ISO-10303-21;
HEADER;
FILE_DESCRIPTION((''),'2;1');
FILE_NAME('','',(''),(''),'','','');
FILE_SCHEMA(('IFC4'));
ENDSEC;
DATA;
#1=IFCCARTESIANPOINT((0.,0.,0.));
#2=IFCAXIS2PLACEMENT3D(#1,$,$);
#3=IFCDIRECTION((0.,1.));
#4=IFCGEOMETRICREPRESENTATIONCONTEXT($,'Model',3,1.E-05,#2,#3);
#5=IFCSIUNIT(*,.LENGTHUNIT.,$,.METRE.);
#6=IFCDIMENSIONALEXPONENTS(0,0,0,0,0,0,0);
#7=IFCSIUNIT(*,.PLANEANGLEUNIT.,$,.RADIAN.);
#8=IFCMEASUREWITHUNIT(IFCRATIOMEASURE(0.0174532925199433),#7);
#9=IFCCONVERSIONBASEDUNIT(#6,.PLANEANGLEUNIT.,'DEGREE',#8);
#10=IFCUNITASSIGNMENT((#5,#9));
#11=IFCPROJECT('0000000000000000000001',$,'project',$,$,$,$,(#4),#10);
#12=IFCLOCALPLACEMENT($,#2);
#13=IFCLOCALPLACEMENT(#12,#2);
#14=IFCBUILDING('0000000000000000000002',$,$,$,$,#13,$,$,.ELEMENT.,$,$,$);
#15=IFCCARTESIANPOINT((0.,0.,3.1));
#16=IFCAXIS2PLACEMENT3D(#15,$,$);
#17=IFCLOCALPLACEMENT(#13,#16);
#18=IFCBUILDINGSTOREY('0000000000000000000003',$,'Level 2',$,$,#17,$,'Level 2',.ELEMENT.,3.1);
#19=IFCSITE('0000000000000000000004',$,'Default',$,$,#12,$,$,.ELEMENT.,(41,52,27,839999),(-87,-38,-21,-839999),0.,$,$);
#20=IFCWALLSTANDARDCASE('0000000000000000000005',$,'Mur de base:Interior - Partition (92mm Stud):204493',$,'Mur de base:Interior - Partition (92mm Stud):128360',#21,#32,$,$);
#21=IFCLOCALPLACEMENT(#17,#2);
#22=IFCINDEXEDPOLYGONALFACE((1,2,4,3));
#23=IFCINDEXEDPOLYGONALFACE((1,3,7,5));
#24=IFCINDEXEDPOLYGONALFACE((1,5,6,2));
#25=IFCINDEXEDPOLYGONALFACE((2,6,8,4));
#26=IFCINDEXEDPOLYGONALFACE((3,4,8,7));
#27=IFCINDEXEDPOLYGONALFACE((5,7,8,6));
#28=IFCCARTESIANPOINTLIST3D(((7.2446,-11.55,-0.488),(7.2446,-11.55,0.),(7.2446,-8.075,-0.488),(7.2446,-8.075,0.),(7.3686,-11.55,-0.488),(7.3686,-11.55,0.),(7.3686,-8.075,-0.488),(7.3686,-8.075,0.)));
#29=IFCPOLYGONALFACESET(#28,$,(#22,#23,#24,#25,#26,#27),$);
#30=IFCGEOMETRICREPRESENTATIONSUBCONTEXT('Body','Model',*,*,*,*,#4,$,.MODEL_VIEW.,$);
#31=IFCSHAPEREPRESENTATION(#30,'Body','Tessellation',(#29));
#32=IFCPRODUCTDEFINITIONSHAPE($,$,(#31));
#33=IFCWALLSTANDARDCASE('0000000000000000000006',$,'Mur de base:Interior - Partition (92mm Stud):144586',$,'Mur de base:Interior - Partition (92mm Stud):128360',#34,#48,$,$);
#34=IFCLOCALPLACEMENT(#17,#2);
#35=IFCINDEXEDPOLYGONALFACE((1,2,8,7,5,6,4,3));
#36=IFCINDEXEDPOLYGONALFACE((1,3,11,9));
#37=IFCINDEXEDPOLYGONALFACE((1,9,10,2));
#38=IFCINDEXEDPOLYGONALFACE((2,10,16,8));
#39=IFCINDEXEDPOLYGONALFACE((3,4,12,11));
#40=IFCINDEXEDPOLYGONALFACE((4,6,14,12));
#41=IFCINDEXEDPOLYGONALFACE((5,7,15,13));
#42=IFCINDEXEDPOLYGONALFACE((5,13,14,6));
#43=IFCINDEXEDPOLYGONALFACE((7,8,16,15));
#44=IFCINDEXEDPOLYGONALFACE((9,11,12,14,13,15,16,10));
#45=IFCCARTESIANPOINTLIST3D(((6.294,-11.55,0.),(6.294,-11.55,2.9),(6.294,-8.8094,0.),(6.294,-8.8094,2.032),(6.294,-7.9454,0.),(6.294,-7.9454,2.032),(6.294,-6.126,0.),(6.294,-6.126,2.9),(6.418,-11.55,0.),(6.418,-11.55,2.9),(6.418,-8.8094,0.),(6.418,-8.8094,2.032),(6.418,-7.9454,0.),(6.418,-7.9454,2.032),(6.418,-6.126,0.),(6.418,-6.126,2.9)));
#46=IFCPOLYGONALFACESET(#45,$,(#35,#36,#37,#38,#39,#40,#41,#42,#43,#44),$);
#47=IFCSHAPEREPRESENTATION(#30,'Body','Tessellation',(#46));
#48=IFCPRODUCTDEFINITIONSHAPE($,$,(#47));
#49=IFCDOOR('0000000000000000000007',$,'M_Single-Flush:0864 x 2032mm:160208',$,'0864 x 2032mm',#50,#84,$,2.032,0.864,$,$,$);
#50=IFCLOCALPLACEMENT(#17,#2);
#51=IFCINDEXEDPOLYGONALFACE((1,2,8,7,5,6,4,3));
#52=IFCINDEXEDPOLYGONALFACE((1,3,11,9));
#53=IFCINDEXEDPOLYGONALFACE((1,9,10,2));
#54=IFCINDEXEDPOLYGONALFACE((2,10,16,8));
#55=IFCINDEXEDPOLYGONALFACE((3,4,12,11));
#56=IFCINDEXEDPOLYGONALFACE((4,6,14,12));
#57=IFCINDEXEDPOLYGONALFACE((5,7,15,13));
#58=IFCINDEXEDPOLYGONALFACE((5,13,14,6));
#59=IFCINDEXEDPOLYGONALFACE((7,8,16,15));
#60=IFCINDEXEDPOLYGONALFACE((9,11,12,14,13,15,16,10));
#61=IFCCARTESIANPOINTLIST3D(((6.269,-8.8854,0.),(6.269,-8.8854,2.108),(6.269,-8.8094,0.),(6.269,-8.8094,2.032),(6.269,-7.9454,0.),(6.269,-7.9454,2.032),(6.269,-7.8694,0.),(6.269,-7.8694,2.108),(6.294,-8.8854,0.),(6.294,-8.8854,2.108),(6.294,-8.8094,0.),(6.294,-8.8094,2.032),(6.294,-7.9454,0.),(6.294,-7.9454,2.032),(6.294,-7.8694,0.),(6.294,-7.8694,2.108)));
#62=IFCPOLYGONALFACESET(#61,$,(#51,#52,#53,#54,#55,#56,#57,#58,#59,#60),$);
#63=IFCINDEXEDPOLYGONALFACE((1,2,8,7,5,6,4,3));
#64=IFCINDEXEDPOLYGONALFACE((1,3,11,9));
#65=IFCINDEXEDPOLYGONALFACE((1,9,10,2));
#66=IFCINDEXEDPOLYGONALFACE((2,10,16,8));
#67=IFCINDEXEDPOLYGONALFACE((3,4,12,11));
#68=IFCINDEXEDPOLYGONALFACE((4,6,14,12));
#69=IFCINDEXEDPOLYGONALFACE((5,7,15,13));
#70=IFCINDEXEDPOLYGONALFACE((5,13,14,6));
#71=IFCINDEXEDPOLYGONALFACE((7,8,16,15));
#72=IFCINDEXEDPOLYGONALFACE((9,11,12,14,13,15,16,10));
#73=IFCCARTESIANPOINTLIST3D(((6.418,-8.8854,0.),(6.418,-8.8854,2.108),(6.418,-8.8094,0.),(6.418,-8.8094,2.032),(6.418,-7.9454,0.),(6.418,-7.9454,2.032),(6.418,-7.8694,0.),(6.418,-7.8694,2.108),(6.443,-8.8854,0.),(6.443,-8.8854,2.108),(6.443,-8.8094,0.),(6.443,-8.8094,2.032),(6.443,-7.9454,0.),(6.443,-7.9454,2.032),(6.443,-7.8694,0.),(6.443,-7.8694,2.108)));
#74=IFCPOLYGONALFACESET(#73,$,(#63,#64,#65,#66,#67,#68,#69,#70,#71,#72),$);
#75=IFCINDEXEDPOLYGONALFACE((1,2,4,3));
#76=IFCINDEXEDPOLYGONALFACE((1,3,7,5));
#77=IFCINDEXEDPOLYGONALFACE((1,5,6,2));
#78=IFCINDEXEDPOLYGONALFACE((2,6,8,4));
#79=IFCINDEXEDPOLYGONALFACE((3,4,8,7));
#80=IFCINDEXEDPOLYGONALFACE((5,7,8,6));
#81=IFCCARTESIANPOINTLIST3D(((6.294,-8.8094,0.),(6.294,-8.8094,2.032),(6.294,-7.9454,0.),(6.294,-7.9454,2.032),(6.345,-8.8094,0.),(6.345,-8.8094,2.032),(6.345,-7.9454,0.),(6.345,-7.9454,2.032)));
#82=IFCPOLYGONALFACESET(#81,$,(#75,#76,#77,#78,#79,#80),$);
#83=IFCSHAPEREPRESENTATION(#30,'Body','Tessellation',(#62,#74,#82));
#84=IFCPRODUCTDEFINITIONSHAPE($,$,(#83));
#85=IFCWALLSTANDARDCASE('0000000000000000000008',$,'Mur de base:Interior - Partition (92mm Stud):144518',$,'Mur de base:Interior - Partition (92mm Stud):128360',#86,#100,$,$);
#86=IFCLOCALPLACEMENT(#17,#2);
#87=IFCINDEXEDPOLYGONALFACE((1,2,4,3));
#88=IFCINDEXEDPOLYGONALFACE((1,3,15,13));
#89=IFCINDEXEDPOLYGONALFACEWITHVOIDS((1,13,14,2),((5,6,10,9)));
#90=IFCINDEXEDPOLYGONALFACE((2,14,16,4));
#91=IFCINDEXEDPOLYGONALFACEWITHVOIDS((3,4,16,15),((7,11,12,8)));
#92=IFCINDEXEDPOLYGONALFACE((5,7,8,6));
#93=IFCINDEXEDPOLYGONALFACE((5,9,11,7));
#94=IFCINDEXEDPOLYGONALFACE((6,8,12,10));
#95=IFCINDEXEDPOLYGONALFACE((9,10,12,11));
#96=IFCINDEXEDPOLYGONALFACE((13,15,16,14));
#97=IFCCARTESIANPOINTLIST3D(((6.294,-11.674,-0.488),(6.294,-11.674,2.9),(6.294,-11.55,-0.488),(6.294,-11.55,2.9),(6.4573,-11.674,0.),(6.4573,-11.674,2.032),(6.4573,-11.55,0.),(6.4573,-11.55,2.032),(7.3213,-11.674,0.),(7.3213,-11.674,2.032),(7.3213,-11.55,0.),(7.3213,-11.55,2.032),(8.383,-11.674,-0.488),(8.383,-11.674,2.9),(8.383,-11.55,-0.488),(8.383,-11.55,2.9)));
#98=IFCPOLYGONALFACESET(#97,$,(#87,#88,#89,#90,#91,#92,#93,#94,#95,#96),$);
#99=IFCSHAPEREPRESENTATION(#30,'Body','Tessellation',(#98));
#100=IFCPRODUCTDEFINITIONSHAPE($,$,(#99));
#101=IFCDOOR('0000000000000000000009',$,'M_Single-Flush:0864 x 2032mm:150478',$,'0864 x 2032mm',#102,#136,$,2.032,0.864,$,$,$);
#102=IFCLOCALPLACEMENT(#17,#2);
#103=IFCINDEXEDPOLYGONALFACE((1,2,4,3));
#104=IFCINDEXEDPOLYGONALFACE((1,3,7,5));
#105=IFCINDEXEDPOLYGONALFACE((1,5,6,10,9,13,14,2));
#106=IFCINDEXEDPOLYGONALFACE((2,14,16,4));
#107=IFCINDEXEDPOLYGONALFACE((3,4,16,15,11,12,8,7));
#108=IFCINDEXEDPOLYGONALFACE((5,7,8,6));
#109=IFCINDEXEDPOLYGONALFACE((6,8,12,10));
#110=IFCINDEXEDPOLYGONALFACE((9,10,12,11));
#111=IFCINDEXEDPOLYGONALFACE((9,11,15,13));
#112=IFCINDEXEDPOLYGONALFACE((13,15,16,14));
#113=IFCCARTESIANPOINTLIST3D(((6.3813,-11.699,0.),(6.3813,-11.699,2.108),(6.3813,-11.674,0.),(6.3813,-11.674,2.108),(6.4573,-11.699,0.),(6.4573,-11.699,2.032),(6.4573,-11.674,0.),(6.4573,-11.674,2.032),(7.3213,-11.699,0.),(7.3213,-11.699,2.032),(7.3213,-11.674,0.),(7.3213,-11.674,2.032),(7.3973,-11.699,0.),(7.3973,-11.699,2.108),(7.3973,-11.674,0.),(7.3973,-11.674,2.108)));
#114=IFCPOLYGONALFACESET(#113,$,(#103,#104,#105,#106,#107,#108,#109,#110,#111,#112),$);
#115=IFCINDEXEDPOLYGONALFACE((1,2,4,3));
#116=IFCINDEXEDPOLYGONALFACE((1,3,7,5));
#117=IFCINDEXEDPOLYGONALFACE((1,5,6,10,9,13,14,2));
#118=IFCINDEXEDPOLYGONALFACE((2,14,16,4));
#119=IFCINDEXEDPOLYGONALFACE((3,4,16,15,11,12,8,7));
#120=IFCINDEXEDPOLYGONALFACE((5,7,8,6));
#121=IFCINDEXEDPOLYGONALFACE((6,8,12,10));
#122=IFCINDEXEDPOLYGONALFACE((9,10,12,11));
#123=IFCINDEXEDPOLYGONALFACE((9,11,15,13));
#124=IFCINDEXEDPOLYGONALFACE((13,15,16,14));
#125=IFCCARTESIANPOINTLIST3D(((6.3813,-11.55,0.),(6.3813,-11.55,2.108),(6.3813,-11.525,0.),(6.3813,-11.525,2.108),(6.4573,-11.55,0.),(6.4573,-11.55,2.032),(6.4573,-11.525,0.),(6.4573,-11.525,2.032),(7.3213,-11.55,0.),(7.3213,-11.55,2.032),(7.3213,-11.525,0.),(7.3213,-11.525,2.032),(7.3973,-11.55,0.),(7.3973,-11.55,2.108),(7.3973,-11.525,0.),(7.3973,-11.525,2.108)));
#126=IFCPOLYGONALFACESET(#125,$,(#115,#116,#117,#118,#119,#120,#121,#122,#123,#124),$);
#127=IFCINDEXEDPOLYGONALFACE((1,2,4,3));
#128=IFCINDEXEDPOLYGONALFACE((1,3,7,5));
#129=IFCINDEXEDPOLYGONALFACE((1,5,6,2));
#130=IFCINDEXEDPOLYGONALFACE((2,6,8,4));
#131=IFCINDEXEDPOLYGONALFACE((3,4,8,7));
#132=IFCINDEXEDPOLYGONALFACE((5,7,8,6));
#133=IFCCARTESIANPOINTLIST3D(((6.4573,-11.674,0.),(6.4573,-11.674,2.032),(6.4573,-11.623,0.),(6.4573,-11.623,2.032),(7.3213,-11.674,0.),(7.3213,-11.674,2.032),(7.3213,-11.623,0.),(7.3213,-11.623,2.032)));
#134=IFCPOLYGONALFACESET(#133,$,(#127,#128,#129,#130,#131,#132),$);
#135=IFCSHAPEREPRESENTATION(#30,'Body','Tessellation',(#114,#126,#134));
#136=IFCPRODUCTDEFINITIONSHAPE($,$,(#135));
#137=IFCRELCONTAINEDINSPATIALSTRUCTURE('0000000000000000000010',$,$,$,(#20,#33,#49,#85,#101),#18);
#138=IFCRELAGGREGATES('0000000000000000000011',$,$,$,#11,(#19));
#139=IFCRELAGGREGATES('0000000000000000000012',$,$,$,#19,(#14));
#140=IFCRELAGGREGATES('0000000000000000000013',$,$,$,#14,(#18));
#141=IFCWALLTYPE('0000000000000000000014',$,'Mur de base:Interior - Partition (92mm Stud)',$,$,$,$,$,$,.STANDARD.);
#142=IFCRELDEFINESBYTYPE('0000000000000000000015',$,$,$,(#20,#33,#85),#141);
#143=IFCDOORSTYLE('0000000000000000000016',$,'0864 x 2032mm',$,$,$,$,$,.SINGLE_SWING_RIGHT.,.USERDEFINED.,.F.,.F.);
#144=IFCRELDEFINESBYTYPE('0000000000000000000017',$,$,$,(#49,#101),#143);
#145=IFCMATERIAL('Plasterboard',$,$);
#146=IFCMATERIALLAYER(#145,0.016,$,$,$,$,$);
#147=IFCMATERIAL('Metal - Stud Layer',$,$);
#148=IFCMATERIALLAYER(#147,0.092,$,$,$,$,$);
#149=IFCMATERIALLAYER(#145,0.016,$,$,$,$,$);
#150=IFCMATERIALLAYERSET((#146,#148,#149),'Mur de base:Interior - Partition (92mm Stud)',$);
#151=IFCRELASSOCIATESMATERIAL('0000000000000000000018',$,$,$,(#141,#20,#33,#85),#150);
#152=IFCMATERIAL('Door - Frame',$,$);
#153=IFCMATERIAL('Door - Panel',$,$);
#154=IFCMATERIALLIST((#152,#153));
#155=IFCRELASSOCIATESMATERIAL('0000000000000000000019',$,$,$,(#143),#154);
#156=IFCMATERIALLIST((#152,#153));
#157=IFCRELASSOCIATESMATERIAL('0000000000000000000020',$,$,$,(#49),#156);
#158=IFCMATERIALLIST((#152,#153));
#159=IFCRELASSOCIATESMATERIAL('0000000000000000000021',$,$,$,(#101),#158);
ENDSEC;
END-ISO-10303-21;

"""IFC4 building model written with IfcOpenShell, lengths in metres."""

from ifc_helpers import new_model, entity, si_unit, converted_unit, direction, frame, frame_2d, origin, origin_2d_with_axis, place, context, subcontext, project, spatial, polyline, rectangle, outline, extrude, source, transform, mapped, material, material_list, layer, layer_set, layer_usage, type_object, type_shapes, element, fill, save


model = new_model("IFC4")

# Units and contexts
model_context = context("Model", 3, precision=1e-05, world=origin(), true_north=direction((0.0, 1.0)))
body_context = subcontext(model_context, "Body", "Model", "MODEL_VIEW")
ifc_project = project(units=[si_unit("LENGTHUNIT", "METRE"), converted_unit("PLANEANGLEUNIT", "DEGREE", entity("IfcRatioMeasure", 0.0174532925199433), si_unit("PLANEANGLEUNIT", "RADIAN"), dimensions=[0, 0, 0, 0, 0, 0, 0])], contexts=[model_context])

# Site, building, storey
site_placement = place(None, origin())
site = spatial("IfcSite", under=ifc_project, at=site_placement, Name="Default", CompositionType="ELEMENT", RefLatitude=(41, 52, 27, 839999), RefLongitude=(-87, -38, -21, -839999), RefElevation=0.0)
building_placement = place(site_placement, origin())
building = spatial("IfcBuilding", under=site, at=building_placement, CompositionType="ELEMENT")
storey_placement = place(building_placement, frame((0.0, 0.0, 3.1)))
storey = spatial("IfcBuildingStorey", under=building, at=storey_placement, Name="Level 2", LongName="Level 2", CompositionType="ELEMENT", Elevation=3.1)

# Wall
ifc_material_1 = material(Name="Plasterboard")
ifc_layer_1 = layer(ifc_material_1, 0.016)
ifc_material_2 = material(Name="Metal - Stud Layer")
ifc_layer_2 = layer(ifc_material_2, 0.092)
ifc_layer_3 = layer(ifc_material_1, 0.016)
ifc_layer_set_1 = layer_set([ifc_layer_1, ifc_layer_2, ifc_layer_3], Name="Mur de base:Interior - Partition (92mm Stud)")
ifc_layer_usage_1 = layer_usage(ifc_layer_set_1, "AXIS2", "NEGATIVE", 0.062)
wall_type_1 = type_object("IfcWallType", Name="Mur de base:Interior - Partition (92mm Stud)", PredefinedType="STANDARD", material=ifc_layer_set_1)
wall_1_placement = place(storey_placement, frame((7.3066, -11.55, -0.488), z_axis=(0.0, 0.0, 1.0), x_axis=(0.0, 1.0, 0.0)))
element("IfcWallStandardCase", 1, at=wall_1_placement, inside=storey, type_object=wall_type_1, material=ifc_layer_usage_1, Name="Mur de base:Interior - Partition (92mm Stud):204493", ObjectType="Mur de base:Interior - Partition (92mm Stud):128360", context=body_context, shape_type="SweptSolid", body=[
    extrude(rectangle(XDim=3.475, YDim=0.124, at=frame_2d((1.7375, 0.0), x_axis=(-1.0, 0.0))), origin(), (0.0, 0.0, 1.0), 0.488),
])

# Wall, openings, door
ifc_layer_usage_2 = layer_usage(ifc_layer_set_1, "AXIS2", "NEGATIVE", 0.062)
wall_2_placement = place(storey_placement, frame((6.356, -11.55, 0.0), z_axis=(0.0, 0.0, 1.0), x_axis=(0.0, 1.0, 0.0)))
wall_2 = element("IfcWallStandardCase", 2, at=wall_2_placement, inside=storey, type_object=wall_type_1, material=ifc_layer_usage_2, Name="Mur de base:Interior - Partition (92mm Stud):144586", ObjectType="Mur de base:Interior - Partition (92mm Stud):128360", context=body_context, shape_type="SweptSolid", body=[
    extrude(rectangle(XDim=5.424, YDim=0.124, at=frame_2d((2.712, 0.0), x_axis=(-1.0, 0.0))), origin(), (0.0, 0.0, 1.0), 2.9),
])
opening_1_placement = place(wall_2_placement, frame((2.7406, -0.062, 0.0)))
opening_1 = element("IfcOpeningElement", 3, at=opening_1_placement, cuts=wall_2, ObjectType="Opening", context=body_context, shape_type="SweptSolid", body=[
    extrude(rectangle(XDim=0.864, YDim=2.032, at=frame_2d((1.016, 0.432), x_axis=(0.0, 1.0))), frame((0.0, 0.0, 0.0), z_axis=(0.0, 1.0, 0.0), x_axis=(0.0, 0.0, 1.0)), (0.0, 0.0, 1.0), 0.124),
])
opening_2_placement = place(wall_2_placement, origin())
element("IfcOpeningElement", 4, at=opening_2_placement, cuts=wall_2, ObjectType="Opening", context=body_context, shape_type="SweptSolid", body=[
    extrude(rectangle(XDim=2.032, YDim=0.124, at=frame_2d((0.0, 0.0), x_axis=(0.0, 1.0))), frame((3.7666, 0.0626, 1.016), z_axis=(0.0, 1.0, 0.0), x_axis=(1.0, 0.0, 0.0)), (0.0, 0.0, 1.0), 0.762),
])
ifc_material_3 = material(Name="Door - Frame")
ifc_material_4 = material(Name="Door - Panel")
ifc_material_list_1 = material_list([ifc_material_3, ifc_material_4])
ifc_material_list_2 = material_list([ifc_material_3, ifc_material_4])
door_style = type_object("IfcDoorStyle", Name="0864 x 2032mm", ConstructionType="USERDEFINED", OperationType="SINGLE_SWING_RIGHT", ParameterTakesPrecedence=False, Sizeable=False, material=ifc_material_list_2)
shared_shape_1 = source(origin(), body_context, "Body", "SweptSolid", [
    extrude(outline(polyline([(-0.508, -1.073), (0.508, -1.073), (0.508, 1.035), (0.432, 1.035), (0.432, -0.997), (-0.432, -0.997), (-0.432, 1.035), (-0.508, 1.035), (-0.508, -1.073)])), frame((0.432, 0.124, 1.035), z_axis=(0.0, 1.0, 0.0), x_axis=(1.0, 0.0, 0.0)), (0.0, 0.0, 1.0), 0.025),
    extrude(outline(polyline([(-1.073, -0.508), (1.035, -0.508), (1.035, -0.432), (-0.997, -0.432), (-0.997, 0.432), (1.035, 0.432), (1.035, 0.508), (-1.073, 0.508), (-1.073, -0.508)])), frame((0.432, -0.025, 1.035), z_axis=(0.0, 1.0, 0.0), x_axis=(0.0, 0.0, -1.0)), (0.0, 0.0, 1.0), 0.025),
    extrude(rectangle(XDim=0.051, YDim=0.864, at=origin_2d_with_axis()), frame((0.432, 0.0985, 0.0), z_axis=(0.0, 0.0, 1.0), x_axis=(0.0, 1.0, 0.0)), (0.0, 0.0, 1.0), 2.032),
])
type_shapes(door_style, [shared_shape_1])
door_1_placement = place(opening_1_placement, origin())
door_1 = element("IfcDoor", 5, at=door_1_placement, inside=storey, type_object=door_style, material=ifc_material_list_1, Name="M_Single-Flush:0864 x 2032mm:160208", ObjectType="0864 x 2032mm", OverallHeight=2.032, OverallWidth=0.864, context=body_context, shape_type="MappedRepresentation", body=[
    mapped(shared_shape_1, transform((0.0, 0.0, 0.0), scale=1.0)),
])
fill(opening_1, door_1)

# Wall, opening, door
ifc_layer_usage_3 = layer_usage(ifc_layer_set_1, "AXIS2", "NEGATIVE", 0.062)
wall_3_placement = place(storey_placement, frame((8.383, -11.612, -0.488), z_axis=(0.0, 0.0, 1.0), x_axis=(-1.0, 0.0, 0.0)))
wall_3 = element("IfcWallStandardCase", 6, at=wall_3_placement, inside=storey, type_object=wall_type_1, material=ifc_layer_usage_3, Name="Mur de base:Interior - Partition (92mm Stud):144518", ObjectType="Mur de base:Interior - Partition (92mm Stud):128360", context=body_context, shape_type="SweptSolid", body=[
    extrude(rectangle(XDim=2.089, YDim=0.124, at=frame_2d((1.0445, 0.0), x_axis=(-1.0, 0.0))), origin(), (0.0, 0.0, 1.0), 3.388),
])
opening_3_placement = place(wall_3_placement, frame((1.0617, -0.062, 0.488)))
opening_3 = element("IfcOpeningElement", 7, at=opening_3_placement, cuts=wall_3, ObjectType="Opening", context=body_context, shape_type="SweptSolid", body=[
    extrude(rectangle(XDim=0.864, YDim=2.032, at=frame_2d((1.016, 0.432), x_axis=(0.0, 1.0))), frame((0.0, 0.0, 0.0), z_axis=(0.0, 1.0, 0.0), x_axis=(0.0, 0.0, 1.0)), (0.0, 0.0, 1.0), 0.124),
])
ifc_material_list_3 = material_list([ifc_material_3, ifc_material_4])
door_2_placement = place(opening_3_placement, origin())
door_2 = element("IfcDoor", 8, at=door_2_placement, inside=storey, type_object=door_style, material=ifc_material_list_3, Name="M_Single-Flush:0864 x 2032mm:150478", ObjectType="0864 x 2032mm", OverallHeight=2.032, OverallWidth=0.864, context=body_context, shape_type="MappedRepresentation", body=[
    mapped(shared_shape_1, transform((0.0, 0.0, 0.0), scale=1.0)),
])
fill(opening_3, door_2)

save(model, "model.ifc")
